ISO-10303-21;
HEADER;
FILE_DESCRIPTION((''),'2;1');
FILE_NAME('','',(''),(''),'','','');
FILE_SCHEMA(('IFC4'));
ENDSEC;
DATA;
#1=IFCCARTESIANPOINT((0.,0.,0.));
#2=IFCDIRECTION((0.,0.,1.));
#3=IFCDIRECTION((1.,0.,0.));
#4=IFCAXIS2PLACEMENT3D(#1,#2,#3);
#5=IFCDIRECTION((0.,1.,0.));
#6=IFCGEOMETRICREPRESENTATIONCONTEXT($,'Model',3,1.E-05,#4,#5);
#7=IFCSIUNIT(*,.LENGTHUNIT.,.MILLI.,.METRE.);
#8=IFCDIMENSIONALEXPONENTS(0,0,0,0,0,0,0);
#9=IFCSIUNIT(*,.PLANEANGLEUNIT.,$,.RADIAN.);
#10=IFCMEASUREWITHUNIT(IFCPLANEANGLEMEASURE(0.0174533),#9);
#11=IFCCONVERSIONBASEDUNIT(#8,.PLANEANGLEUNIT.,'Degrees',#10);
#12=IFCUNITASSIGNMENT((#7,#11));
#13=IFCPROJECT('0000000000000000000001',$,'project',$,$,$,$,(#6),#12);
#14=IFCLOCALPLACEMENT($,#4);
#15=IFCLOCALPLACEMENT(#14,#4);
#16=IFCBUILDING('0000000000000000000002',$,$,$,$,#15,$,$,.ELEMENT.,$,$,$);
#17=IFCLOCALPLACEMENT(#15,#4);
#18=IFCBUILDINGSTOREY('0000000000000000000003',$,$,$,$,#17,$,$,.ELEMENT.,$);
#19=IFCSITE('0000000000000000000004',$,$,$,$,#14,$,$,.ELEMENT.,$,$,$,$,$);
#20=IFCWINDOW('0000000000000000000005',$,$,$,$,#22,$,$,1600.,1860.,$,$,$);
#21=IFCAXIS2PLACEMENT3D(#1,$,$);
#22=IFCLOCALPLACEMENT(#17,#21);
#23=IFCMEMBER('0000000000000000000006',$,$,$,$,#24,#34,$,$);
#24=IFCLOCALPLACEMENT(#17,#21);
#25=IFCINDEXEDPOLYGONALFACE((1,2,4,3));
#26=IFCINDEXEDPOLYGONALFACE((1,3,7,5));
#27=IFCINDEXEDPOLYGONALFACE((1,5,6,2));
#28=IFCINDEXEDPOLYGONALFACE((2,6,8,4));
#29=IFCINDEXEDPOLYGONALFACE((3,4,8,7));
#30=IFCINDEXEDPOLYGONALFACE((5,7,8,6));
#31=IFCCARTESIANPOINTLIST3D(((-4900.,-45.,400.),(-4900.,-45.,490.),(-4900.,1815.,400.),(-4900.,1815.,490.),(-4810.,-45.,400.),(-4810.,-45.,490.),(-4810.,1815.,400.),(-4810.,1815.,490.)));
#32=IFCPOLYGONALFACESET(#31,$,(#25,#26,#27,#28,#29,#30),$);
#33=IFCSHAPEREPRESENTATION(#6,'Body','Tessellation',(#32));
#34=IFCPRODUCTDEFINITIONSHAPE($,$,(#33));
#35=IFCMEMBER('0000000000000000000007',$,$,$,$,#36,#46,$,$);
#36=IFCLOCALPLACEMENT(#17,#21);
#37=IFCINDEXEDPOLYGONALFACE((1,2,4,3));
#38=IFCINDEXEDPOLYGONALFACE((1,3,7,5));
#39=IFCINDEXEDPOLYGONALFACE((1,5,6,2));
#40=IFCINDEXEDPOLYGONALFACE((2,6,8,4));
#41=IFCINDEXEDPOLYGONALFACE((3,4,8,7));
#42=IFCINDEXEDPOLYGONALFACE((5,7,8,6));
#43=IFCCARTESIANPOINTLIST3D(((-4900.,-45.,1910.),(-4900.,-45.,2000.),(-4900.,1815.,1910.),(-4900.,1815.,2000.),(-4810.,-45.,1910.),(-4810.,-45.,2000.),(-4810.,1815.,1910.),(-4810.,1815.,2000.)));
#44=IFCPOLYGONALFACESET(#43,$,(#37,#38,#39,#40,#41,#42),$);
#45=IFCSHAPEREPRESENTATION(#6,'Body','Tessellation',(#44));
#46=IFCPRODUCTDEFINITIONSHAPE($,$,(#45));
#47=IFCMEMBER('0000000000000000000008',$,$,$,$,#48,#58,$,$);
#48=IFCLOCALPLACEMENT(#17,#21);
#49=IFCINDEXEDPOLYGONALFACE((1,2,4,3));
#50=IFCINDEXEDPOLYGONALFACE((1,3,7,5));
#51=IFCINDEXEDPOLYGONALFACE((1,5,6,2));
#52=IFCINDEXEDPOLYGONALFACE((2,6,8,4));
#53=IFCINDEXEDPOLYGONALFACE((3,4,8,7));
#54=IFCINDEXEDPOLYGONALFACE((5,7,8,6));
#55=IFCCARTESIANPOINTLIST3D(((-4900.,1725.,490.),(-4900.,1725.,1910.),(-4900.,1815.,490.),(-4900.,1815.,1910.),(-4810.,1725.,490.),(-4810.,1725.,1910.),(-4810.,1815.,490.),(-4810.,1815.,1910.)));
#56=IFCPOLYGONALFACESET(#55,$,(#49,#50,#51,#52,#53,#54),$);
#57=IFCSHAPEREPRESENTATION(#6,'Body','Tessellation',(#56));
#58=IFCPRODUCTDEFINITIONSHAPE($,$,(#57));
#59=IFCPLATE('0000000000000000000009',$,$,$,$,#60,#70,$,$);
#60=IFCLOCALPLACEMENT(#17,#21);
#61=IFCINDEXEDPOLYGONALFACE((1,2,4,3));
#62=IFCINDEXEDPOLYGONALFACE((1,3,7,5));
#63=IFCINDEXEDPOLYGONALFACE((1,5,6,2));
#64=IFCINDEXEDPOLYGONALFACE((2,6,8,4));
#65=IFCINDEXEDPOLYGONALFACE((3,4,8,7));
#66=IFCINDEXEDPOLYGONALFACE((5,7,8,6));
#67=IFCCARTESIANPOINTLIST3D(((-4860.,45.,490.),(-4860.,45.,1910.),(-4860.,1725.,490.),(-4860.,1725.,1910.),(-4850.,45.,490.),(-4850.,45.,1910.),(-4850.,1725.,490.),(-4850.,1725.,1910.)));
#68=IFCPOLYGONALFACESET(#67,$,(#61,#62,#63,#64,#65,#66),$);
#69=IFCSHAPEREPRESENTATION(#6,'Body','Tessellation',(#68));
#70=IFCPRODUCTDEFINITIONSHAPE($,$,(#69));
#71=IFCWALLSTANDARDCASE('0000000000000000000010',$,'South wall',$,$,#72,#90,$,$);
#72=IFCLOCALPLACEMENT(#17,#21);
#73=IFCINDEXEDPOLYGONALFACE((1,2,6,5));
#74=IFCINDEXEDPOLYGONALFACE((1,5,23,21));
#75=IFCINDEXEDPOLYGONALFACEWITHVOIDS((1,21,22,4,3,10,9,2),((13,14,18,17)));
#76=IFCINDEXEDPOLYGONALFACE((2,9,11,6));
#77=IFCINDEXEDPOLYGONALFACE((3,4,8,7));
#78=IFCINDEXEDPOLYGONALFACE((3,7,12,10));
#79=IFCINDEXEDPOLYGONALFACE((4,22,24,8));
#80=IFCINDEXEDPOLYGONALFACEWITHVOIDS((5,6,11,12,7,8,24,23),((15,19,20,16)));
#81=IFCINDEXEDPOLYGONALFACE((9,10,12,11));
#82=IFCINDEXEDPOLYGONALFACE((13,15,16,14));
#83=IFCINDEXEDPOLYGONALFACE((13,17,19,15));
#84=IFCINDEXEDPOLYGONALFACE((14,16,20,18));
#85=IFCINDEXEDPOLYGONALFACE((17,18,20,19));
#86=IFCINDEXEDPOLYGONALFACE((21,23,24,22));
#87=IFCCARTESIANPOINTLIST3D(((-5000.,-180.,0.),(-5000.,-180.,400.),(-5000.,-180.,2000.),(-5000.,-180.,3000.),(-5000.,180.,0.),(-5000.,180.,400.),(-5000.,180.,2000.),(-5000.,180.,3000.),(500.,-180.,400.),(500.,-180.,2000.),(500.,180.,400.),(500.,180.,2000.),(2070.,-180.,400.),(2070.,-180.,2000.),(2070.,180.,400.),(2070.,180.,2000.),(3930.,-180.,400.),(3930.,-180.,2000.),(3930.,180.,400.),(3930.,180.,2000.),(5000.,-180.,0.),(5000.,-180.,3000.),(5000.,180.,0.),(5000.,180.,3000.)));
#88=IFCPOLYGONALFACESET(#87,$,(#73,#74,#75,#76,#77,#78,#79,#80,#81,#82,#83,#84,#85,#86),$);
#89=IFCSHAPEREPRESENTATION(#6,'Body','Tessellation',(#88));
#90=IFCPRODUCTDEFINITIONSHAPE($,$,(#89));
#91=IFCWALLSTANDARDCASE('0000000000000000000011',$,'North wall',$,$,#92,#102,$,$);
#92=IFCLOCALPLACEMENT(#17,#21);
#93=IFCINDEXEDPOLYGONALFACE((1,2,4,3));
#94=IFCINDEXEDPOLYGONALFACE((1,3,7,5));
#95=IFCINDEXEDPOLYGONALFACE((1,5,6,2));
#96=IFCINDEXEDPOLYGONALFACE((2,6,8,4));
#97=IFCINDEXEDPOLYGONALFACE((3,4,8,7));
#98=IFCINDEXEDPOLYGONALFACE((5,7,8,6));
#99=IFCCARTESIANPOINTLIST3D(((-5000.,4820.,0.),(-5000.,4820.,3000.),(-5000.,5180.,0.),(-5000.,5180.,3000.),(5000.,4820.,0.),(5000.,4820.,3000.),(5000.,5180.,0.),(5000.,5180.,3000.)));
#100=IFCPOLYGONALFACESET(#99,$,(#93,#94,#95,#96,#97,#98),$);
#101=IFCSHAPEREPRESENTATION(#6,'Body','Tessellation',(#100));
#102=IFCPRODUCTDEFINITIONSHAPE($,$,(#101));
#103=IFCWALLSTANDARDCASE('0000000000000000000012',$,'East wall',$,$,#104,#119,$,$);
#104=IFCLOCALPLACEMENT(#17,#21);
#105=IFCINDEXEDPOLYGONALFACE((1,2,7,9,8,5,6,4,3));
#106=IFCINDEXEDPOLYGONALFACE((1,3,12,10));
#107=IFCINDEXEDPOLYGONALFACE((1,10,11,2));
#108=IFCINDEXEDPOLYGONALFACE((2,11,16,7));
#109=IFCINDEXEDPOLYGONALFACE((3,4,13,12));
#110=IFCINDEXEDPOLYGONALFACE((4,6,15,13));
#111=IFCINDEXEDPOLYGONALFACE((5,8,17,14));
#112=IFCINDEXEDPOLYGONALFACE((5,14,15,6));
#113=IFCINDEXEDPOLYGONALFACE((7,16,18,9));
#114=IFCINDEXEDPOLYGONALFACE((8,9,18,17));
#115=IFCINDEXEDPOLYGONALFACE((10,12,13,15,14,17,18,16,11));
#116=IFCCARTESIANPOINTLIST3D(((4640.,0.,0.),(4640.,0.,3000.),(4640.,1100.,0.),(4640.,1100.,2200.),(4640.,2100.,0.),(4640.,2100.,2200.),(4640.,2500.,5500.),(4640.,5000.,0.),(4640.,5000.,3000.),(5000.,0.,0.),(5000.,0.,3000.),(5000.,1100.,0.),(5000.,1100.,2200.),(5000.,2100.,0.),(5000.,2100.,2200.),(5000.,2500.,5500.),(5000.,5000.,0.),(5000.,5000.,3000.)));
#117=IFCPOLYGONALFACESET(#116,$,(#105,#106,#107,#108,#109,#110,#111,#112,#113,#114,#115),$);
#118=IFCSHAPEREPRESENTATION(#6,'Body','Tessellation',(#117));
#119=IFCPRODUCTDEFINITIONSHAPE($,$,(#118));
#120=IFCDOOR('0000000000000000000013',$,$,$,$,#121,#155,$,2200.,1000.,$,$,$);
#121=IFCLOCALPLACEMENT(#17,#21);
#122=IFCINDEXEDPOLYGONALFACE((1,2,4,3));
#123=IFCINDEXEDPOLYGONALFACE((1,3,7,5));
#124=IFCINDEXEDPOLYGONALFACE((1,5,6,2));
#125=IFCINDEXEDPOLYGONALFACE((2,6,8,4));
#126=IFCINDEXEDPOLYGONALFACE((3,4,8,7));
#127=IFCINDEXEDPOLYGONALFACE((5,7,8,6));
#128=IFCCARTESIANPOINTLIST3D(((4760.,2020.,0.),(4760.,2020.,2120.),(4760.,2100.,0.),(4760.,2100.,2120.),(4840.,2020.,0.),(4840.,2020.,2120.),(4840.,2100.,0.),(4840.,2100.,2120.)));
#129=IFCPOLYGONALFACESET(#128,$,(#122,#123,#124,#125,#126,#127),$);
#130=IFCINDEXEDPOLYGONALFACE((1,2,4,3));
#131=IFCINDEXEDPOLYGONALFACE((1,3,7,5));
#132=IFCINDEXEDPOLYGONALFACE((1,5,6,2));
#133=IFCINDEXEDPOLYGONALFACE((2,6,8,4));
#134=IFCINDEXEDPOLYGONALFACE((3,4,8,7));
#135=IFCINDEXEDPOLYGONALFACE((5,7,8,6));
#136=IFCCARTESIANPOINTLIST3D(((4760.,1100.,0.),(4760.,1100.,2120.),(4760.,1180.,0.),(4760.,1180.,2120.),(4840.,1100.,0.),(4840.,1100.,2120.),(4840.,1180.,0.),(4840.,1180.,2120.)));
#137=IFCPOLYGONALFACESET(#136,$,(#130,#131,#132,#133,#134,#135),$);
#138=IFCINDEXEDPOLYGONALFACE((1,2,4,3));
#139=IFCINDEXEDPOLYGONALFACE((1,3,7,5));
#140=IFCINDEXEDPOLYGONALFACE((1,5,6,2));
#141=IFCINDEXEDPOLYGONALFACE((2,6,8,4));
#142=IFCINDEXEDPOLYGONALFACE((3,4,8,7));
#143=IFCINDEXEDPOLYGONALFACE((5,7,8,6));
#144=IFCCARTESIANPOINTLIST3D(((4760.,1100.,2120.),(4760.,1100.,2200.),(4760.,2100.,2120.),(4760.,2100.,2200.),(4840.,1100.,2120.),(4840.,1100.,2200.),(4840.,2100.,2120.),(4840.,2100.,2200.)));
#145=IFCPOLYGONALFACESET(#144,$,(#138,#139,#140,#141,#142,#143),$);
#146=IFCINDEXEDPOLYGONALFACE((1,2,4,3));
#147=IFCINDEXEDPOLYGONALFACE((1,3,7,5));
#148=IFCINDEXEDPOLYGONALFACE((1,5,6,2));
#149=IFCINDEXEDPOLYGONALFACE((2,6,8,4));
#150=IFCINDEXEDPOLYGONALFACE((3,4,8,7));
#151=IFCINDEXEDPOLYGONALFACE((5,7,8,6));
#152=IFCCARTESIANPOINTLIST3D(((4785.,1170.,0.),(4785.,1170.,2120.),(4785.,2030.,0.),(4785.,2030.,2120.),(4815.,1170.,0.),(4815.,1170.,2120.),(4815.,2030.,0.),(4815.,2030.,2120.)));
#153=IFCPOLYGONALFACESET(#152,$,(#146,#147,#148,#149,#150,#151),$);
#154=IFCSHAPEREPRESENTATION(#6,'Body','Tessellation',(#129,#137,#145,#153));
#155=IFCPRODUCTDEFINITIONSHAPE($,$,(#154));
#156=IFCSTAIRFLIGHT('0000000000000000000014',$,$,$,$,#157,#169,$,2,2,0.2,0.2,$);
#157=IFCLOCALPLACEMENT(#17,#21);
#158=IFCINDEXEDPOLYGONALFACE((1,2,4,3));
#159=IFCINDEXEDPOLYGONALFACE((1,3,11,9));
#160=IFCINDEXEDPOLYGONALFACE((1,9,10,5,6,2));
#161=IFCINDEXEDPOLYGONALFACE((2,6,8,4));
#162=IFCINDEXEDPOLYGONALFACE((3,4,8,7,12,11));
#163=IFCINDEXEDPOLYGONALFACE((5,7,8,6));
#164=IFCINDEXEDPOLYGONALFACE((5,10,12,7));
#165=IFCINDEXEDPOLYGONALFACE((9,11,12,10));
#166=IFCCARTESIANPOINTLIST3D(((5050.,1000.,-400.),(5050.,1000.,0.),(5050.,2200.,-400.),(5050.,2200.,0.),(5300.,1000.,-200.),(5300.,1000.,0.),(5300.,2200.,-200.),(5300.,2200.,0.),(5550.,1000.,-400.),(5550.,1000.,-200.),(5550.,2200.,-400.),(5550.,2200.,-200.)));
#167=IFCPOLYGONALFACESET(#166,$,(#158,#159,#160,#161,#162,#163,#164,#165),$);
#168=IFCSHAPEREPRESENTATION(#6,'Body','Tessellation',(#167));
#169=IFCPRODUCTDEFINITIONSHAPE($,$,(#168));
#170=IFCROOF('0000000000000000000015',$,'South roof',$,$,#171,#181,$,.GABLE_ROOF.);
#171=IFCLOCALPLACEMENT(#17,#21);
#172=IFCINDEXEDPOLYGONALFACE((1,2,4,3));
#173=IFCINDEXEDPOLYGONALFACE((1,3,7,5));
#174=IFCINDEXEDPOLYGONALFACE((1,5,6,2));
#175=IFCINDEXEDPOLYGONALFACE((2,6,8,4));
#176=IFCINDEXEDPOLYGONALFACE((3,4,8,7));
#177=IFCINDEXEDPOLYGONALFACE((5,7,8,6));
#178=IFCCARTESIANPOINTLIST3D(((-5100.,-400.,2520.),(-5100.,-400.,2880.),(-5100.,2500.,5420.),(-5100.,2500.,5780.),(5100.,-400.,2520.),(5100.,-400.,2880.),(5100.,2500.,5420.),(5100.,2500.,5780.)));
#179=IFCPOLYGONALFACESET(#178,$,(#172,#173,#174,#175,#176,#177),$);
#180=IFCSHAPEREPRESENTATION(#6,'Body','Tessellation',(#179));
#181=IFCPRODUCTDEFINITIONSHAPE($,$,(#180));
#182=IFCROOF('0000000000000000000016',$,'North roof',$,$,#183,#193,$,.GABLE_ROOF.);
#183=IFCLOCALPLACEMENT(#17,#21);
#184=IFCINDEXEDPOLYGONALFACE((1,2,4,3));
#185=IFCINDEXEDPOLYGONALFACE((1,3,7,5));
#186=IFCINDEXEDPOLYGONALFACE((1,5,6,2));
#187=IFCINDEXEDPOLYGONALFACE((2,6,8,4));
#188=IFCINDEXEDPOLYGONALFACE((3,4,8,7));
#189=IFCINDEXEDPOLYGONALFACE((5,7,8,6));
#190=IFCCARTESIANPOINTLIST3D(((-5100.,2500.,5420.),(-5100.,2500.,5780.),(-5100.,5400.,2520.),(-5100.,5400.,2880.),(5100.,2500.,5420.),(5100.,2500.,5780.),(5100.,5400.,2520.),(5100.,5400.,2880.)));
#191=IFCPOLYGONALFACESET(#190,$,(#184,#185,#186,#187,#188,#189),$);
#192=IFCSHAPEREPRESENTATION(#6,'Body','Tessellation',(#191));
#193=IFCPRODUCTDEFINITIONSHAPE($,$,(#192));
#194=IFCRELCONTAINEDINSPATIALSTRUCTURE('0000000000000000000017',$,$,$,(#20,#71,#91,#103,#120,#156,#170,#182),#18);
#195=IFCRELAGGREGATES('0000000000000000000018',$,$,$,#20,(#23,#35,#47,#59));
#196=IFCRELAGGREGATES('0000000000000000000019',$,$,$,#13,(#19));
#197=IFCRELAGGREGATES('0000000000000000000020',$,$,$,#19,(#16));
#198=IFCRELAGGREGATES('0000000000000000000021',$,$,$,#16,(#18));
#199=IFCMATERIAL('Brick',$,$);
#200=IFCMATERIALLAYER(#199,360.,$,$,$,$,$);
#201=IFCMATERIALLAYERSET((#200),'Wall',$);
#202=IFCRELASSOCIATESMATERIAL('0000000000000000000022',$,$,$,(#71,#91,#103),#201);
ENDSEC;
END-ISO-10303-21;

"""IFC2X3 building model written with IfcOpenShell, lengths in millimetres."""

from ifc_helpers import new_model, entity, si_unit, converted_unit, direction, frame, origin_with_axes, place, context, project, spatial, polyline, outline, extrude, clip, halfspace, material, layer, layer_set, layer_usage, element, fill, aggregate, save


model = new_model("IFC2X3")

# Units and contexts
model_context = context("Model", 3, precision=1e-05, world=origin_with_axes(), true_north=direction((0.0, 1.0, 0.0)))
ifc_project = project(units=[si_unit("LENGTHUNIT", "METRE", prefix="MILLI"), converted_unit("PLANEANGLEUNIT", "Degrees", entity("IfcPlaneAngleMeasure", 0.0174533), si_unit("PLANEANGLEUNIT", "RADIAN"), dimensions=[0, 0, 0, 0, 0, 0, 0])], contexts=[model_context])

# Site, building, storey
placement = place(None, origin_with_axes())
site = spatial("IfcSite", under=ifc_project, at=placement, CompositionType="ELEMENT")
building_placement = place(placement, origin_with_axes())
building = spatial("IfcBuilding", under=site, at=building_placement, CompositionType="ELEMENT")
storey_placement = place(building_placement, origin_with_axes())
storey = spatial("IfcBuildingStorey", under=building, at=storey_placement, CompositionType="ELEMENT")

# Window, members
window_1_placement = place(storey_placement, frame((-4810.0, -45.0, 400.0), z_axis=(0.0, 0.0, 1.0), x_axis=(0.0, 1.0, 0.0)))
window_1 = element("IfcWindow", 1, at=window_1_placement, inside=storey, OverallHeight=1600.0, OverallWidth=1860.0)
member_1_placement = place(window_1_placement, frame((930.0, 45.0, 0.0), z_axis=(0.0, 0.0, 1.0), x_axis=(1.0, 0.0, 0.0)))
member_1 = element("IfcMember", 2, at=member_1_placement, context=model_context, shape_type="SweptSolid", body=[
    extrude(outline(polyline([(-930.0, -45.0), (930.0, -45.0), (930.0, 45.0), (-930.0, 45.0), (-930.0, -45.0), (-930.0, -45.0)])), origin_with_axes(), (0.0, 0.0, 1.0), 90.0),
])
member_2_placement = place(window_1_placement, frame((930.0, 45.0, 1510.0), z_axis=(0.0, 0.0, 1.0), x_axis=(1.0, 0.0, 0.0)))
member_2 = element("IfcMember", 3, at=member_2_placement, context=model_context, shape_type="SweptSolid", body=[
    extrude(outline(polyline([(-930.0, -45.0), (930.0, -45.0), (930.0, 45.0), (-930.0, 45.0), (-930.0, -45.0), (-930.0, -45.0)])), origin_with_axes(), (0.0, 0.0, 1.0), 90.0),
])
member_3_placement = place(window_1_placement, frame((1815.0, 45.0, 90.0), z_axis=(0.0, 0.0, 1.0), x_axis=(1.0, 0.0, 0.0)))
member_3 = element("IfcMember", 4, at=member_3_placement, context=model_context, shape_type="SweptSolid", body=[
    extrude(outline(polyline([(-45.0, -45.0), (45.0, -45.0), (45.0, 45.0), (-45.0, 45.0), (-45.0, -45.0), (-45.0, -45.0)])), origin_with_axes(), (0.0, 0.0, 1.0), 1420.0),
])

# Plate
plate_1_placement = place(window_1_placement, frame((930.0, 45.0, 90.0), z_axis=(0.0, 0.0, 1.0), x_axis=(1.0, 0.0, 0.0)))
plate_1 = element("IfcPlate", 5, at=plate_1_placement, context=model_context, shape_type="SweptSolid", body=[
    extrude(outline(polyline([(-840.0, -5.0), (840.0, -5.0), (840.0, 5.0), (-840.0, 5.0), (-840.0, -5.0), (-840.0, -5.0)])), origin_with_axes(), (0.0, 0.0, 1.0), 1420.0),
])
aggregate(window_1, [member_1, member_2, member_3, plate_1])

# Wall, openings
ifc_material = material(Name="Brick")
ifc_layer = layer(ifc_material, 360.0)
ifc_layer_set = layer_set([ifc_layer], Name="Wall")
ifc_layer_usage = layer_usage(ifc_layer_set, "AXIS2", "POSITIVE", -180.0)
wall_1 = element("IfcWallStandardCase", 6, at=placement, inside=storey, material=ifc_layer_usage, Name="South wall", context=model_context, shape_type="SweptSolid", body=[
    extrude(outline(polyline([(-5000.0, -180.0), (5000.0, -180.0), (5000.0, 180.0), (-5000.0, 180.0), (-5000.0, -180.0), (-5000.0, -180.0)])), origin_with_axes(), (0.0, 0.0, 1.0), 3000.0),
])
opening_1_placement = place(None, frame((-2500.0, 0.0, 400.0), z_axis=(0.0, 0.0, 1.0), x_axis=(1.0, 0.0, 0.0)))
element("IfcOpeningElement", 7, at=opening_1_placement, cuts=wall_1, context=model_context, shape_type="SweptSolid", body=[
    extrude(outline(polyline([(-3000.0, -1815.0), (3000.0, -1815.0), (3000.0, 1815.0), (-3000.0, 1815.0), (-3000.0, -1815.0), (-3000.0, -1815.0)])), origin_with_axes(), (0.0, 0.0, 1.0), 1600.0),
])
opening_2_placement = place(None, frame((3000.0, 0.0, 400.0), z_axis=(0.0, 0.0, 1.0), x_axis=(1.0, 0.0, 0.0)))
element("IfcOpeningElement", 8, at=opening_2_placement, cuts=wall_1, context=model_context, shape_type="SweptSolid", body=[
    extrude(outline(polyline([(-930.0, -1500.0), (930.0, -1500.0), (930.0, 1500.0), (-930.0, 1500.0), (-930.0, -1500.0), (-930.0, -1500.0)])), origin_with_axes(), (0.0, 0.0, 1.0), 1600.0),
])

# Wall
wall_2_placement = place(storey_placement, frame((0.0, 5000.0, 0.0), z_axis=(0.0, 0.0, 1.0), x_axis=(1.0, 0.0, 0.0)))
element("IfcWallStandardCase", 9, at=wall_2_placement, inside=storey, material=ifc_layer_usage, Name="North wall", context=model_context, shape_type="SweptSolid", body=[
    extrude(outline(polyline([(-5000.0, -180.0), (5000.0, -180.0), (5000.0, 180.0), (-5000.0, 180.0), (-5000.0, -180.0), (-5000.0, -180.0)])), origin_with_axes(), (0.0, 0.0, 1.0), 3000.0),
])

# Wall, opening, door
wall_3_placement = place(storey_placement, frame((4820.0, 2500.0, 0.0), z_axis=(0.0, 0.0, 1.0), x_axis=(0.0, 1.0, 0.0)))
wall_3 = element("IfcWallStandardCase", 10, at=wall_3_placement, inside=storey, material=ifc_layer_usage, Name="East wall", context=model_context, shape_type="Clipping", body=[
    clip(clip(extrude(outline(polyline([(-2500.0, -180.0), (2500.0, -180.0), (2500.0, 180.0), (-2500.0, 180.0), (-2500.0, -180.0), (-2500.0, -180.0)])), origin_with_axes(), (0.0, 0.0, 1.0), 6000.0), halfspace(frame((-2500.0, 0.0, 3000.0), z_axis=(-1.0, 0.0, 1.0), x_axis=(1.0, 0.0, 0.0)), False)), halfspace(frame((2500.0, 0.0, 3000.0), z_axis=(1.0, 0.0, 1.0), x_axis=(1.0, 0.0, 0.0)), False)),
])
opening_3_placement = place(None, frame((4820.0, 1600.0, 0.0), z_axis=(0.0, 0.0, 1.0), x_axis=(1.0, 0.0, 0.0)))
opening_3 = element("IfcOpeningElement", 11, at=opening_3_placement, cuts=wall_3, context=model_context, shape_type="SweptSolid", body=[
    extrude(outline(polyline([(-500.0, -500.0), (500.0, -500.0), (500.0, 500.0), (-500.0, 500.0), (-500.0, -500.0), (-500.0, -500.0)])), origin_with_axes(), (0.0, 0.0, 1.0), 2200.0),
])
door_placement = place(storey_placement, frame((4800.0, 1600.0, 0.0), z_axis=(0.0, 0.0, 1.0), x_axis=(0.0, 1.0, 0.0)))
door = element("IfcDoor", 12, at=door_placement, inside=storey, OverallHeight=2200.0, OverallWidth=1000.0, context=model_context, shape_type="SweptSolid", body=[
    extrude(outline(polyline([(-40.0, -40.0), (40.0, -40.0), (40.0, 40.0), (-40.0, 40.0), (-40.0, -40.0), (-40.0, -40.0)])), frame((460.0, 0.0, 0.0), z_axis=(0.0, 0.0, 1.0), x_axis=(1.0, 0.0, 0.0)), (0.0, 0.0, 1.0), 2120.0),
    extrude(outline(polyline([(-40.0, -40.0), (40.0, -40.0), (40.0, 40.0), (-40.0, 40.0), (-40.0, -40.0), (-40.0, -40.0)])), frame((-460.0, 0.0, 0.0), z_axis=(0.0, 0.0, 1.0), x_axis=(1.0, 0.0, 0.0)), (0.0, 0.0, 1.0), 2120.0),
    extrude(outline(polyline([(-500.0, -40.0), (500.0, -40.0), (500.0, 40.0), (-500.0, 40.0), (-500.0, -40.0), (-500.0, -40.0)])), frame((0.0, 0.0, 2120.0), z_axis=(0.0, 0.0, 1.0), x_axis=(1.0, 0.0, 0.0)), (0.0, 0.0, 1.0), 80.0),
    extrude(outline(polyline([(-430.0, -15.0), (430.0, -15.0), (430.0, 15.0), (-430.0, 15.0), (-430.0, -15.0), (-430.0, -15.0)])), origin_with_axes(), (0.0, 0.0, 1.0), 2120.0),
])
fill(opening_3, door)

# Stair flight
stair_flight_placement = place(storey_placement, frame((5050.0, 1000.0, 0.0), z_axis=(0.0, 1.0, 0.0), x_axis=(1.0, 0.0, 0.0)))
element("IfcStairFlight", 13, at=stair_flight_placement, inside=storey, NumberOfRiser=2, NumberOfTreads=2, RiserHeight=0.2, TreadLength=0.2, context=model_context, shape_type="SweptSolid", body=[
    extrude(outline(polyline([(0.0, 0.0), (250.0, 0.0), (250.0, 200.0), (500.0, 200.0), (500.0, 400.0), (0.0, 400.0), (0.0, 0.0)])), origin_with_axes(), (0.0, 0.0, 1.0), 1200.0),
])

# Roofs
for number, where, z_axis, x_axis, name in (
    (14, (0.0, -400.0, 2700.0), (0.0, 0.0, 1.0), (1.0, 0.0, 0.0), "South roof"),
    (15, (0.0, 5400.0, 2700.0), (0.0, 0.0, 1.0), (-1.0, 0.0, 0.0), "North roof"),
):
    element("IfcRoof", number, at=place(storey_placement, frame(where, z_axis=z_axis, x_axis=x_axis)), inside=storey, Name=name, ShapeType="GABLE_ROOF", context=model_context, shape_type="SweptSolid", body=[
        extrude(outline(polyline([(-5100.0, -180.0), (5100.0, -180.0), (5100.0, 180.0), (-5100.0, 180.0), (-5100.0, -180.0), (-5100.0, -180.0)])), frame((0.0, 0.0, 0.0), z_axis=(0.0, 1.0, 0.0), x_axis=(1.0, 0.0, 0.0)), (0.0, -0.707107, 0.707107), 4101.2),
    ])

save(model, "model.ifc")
